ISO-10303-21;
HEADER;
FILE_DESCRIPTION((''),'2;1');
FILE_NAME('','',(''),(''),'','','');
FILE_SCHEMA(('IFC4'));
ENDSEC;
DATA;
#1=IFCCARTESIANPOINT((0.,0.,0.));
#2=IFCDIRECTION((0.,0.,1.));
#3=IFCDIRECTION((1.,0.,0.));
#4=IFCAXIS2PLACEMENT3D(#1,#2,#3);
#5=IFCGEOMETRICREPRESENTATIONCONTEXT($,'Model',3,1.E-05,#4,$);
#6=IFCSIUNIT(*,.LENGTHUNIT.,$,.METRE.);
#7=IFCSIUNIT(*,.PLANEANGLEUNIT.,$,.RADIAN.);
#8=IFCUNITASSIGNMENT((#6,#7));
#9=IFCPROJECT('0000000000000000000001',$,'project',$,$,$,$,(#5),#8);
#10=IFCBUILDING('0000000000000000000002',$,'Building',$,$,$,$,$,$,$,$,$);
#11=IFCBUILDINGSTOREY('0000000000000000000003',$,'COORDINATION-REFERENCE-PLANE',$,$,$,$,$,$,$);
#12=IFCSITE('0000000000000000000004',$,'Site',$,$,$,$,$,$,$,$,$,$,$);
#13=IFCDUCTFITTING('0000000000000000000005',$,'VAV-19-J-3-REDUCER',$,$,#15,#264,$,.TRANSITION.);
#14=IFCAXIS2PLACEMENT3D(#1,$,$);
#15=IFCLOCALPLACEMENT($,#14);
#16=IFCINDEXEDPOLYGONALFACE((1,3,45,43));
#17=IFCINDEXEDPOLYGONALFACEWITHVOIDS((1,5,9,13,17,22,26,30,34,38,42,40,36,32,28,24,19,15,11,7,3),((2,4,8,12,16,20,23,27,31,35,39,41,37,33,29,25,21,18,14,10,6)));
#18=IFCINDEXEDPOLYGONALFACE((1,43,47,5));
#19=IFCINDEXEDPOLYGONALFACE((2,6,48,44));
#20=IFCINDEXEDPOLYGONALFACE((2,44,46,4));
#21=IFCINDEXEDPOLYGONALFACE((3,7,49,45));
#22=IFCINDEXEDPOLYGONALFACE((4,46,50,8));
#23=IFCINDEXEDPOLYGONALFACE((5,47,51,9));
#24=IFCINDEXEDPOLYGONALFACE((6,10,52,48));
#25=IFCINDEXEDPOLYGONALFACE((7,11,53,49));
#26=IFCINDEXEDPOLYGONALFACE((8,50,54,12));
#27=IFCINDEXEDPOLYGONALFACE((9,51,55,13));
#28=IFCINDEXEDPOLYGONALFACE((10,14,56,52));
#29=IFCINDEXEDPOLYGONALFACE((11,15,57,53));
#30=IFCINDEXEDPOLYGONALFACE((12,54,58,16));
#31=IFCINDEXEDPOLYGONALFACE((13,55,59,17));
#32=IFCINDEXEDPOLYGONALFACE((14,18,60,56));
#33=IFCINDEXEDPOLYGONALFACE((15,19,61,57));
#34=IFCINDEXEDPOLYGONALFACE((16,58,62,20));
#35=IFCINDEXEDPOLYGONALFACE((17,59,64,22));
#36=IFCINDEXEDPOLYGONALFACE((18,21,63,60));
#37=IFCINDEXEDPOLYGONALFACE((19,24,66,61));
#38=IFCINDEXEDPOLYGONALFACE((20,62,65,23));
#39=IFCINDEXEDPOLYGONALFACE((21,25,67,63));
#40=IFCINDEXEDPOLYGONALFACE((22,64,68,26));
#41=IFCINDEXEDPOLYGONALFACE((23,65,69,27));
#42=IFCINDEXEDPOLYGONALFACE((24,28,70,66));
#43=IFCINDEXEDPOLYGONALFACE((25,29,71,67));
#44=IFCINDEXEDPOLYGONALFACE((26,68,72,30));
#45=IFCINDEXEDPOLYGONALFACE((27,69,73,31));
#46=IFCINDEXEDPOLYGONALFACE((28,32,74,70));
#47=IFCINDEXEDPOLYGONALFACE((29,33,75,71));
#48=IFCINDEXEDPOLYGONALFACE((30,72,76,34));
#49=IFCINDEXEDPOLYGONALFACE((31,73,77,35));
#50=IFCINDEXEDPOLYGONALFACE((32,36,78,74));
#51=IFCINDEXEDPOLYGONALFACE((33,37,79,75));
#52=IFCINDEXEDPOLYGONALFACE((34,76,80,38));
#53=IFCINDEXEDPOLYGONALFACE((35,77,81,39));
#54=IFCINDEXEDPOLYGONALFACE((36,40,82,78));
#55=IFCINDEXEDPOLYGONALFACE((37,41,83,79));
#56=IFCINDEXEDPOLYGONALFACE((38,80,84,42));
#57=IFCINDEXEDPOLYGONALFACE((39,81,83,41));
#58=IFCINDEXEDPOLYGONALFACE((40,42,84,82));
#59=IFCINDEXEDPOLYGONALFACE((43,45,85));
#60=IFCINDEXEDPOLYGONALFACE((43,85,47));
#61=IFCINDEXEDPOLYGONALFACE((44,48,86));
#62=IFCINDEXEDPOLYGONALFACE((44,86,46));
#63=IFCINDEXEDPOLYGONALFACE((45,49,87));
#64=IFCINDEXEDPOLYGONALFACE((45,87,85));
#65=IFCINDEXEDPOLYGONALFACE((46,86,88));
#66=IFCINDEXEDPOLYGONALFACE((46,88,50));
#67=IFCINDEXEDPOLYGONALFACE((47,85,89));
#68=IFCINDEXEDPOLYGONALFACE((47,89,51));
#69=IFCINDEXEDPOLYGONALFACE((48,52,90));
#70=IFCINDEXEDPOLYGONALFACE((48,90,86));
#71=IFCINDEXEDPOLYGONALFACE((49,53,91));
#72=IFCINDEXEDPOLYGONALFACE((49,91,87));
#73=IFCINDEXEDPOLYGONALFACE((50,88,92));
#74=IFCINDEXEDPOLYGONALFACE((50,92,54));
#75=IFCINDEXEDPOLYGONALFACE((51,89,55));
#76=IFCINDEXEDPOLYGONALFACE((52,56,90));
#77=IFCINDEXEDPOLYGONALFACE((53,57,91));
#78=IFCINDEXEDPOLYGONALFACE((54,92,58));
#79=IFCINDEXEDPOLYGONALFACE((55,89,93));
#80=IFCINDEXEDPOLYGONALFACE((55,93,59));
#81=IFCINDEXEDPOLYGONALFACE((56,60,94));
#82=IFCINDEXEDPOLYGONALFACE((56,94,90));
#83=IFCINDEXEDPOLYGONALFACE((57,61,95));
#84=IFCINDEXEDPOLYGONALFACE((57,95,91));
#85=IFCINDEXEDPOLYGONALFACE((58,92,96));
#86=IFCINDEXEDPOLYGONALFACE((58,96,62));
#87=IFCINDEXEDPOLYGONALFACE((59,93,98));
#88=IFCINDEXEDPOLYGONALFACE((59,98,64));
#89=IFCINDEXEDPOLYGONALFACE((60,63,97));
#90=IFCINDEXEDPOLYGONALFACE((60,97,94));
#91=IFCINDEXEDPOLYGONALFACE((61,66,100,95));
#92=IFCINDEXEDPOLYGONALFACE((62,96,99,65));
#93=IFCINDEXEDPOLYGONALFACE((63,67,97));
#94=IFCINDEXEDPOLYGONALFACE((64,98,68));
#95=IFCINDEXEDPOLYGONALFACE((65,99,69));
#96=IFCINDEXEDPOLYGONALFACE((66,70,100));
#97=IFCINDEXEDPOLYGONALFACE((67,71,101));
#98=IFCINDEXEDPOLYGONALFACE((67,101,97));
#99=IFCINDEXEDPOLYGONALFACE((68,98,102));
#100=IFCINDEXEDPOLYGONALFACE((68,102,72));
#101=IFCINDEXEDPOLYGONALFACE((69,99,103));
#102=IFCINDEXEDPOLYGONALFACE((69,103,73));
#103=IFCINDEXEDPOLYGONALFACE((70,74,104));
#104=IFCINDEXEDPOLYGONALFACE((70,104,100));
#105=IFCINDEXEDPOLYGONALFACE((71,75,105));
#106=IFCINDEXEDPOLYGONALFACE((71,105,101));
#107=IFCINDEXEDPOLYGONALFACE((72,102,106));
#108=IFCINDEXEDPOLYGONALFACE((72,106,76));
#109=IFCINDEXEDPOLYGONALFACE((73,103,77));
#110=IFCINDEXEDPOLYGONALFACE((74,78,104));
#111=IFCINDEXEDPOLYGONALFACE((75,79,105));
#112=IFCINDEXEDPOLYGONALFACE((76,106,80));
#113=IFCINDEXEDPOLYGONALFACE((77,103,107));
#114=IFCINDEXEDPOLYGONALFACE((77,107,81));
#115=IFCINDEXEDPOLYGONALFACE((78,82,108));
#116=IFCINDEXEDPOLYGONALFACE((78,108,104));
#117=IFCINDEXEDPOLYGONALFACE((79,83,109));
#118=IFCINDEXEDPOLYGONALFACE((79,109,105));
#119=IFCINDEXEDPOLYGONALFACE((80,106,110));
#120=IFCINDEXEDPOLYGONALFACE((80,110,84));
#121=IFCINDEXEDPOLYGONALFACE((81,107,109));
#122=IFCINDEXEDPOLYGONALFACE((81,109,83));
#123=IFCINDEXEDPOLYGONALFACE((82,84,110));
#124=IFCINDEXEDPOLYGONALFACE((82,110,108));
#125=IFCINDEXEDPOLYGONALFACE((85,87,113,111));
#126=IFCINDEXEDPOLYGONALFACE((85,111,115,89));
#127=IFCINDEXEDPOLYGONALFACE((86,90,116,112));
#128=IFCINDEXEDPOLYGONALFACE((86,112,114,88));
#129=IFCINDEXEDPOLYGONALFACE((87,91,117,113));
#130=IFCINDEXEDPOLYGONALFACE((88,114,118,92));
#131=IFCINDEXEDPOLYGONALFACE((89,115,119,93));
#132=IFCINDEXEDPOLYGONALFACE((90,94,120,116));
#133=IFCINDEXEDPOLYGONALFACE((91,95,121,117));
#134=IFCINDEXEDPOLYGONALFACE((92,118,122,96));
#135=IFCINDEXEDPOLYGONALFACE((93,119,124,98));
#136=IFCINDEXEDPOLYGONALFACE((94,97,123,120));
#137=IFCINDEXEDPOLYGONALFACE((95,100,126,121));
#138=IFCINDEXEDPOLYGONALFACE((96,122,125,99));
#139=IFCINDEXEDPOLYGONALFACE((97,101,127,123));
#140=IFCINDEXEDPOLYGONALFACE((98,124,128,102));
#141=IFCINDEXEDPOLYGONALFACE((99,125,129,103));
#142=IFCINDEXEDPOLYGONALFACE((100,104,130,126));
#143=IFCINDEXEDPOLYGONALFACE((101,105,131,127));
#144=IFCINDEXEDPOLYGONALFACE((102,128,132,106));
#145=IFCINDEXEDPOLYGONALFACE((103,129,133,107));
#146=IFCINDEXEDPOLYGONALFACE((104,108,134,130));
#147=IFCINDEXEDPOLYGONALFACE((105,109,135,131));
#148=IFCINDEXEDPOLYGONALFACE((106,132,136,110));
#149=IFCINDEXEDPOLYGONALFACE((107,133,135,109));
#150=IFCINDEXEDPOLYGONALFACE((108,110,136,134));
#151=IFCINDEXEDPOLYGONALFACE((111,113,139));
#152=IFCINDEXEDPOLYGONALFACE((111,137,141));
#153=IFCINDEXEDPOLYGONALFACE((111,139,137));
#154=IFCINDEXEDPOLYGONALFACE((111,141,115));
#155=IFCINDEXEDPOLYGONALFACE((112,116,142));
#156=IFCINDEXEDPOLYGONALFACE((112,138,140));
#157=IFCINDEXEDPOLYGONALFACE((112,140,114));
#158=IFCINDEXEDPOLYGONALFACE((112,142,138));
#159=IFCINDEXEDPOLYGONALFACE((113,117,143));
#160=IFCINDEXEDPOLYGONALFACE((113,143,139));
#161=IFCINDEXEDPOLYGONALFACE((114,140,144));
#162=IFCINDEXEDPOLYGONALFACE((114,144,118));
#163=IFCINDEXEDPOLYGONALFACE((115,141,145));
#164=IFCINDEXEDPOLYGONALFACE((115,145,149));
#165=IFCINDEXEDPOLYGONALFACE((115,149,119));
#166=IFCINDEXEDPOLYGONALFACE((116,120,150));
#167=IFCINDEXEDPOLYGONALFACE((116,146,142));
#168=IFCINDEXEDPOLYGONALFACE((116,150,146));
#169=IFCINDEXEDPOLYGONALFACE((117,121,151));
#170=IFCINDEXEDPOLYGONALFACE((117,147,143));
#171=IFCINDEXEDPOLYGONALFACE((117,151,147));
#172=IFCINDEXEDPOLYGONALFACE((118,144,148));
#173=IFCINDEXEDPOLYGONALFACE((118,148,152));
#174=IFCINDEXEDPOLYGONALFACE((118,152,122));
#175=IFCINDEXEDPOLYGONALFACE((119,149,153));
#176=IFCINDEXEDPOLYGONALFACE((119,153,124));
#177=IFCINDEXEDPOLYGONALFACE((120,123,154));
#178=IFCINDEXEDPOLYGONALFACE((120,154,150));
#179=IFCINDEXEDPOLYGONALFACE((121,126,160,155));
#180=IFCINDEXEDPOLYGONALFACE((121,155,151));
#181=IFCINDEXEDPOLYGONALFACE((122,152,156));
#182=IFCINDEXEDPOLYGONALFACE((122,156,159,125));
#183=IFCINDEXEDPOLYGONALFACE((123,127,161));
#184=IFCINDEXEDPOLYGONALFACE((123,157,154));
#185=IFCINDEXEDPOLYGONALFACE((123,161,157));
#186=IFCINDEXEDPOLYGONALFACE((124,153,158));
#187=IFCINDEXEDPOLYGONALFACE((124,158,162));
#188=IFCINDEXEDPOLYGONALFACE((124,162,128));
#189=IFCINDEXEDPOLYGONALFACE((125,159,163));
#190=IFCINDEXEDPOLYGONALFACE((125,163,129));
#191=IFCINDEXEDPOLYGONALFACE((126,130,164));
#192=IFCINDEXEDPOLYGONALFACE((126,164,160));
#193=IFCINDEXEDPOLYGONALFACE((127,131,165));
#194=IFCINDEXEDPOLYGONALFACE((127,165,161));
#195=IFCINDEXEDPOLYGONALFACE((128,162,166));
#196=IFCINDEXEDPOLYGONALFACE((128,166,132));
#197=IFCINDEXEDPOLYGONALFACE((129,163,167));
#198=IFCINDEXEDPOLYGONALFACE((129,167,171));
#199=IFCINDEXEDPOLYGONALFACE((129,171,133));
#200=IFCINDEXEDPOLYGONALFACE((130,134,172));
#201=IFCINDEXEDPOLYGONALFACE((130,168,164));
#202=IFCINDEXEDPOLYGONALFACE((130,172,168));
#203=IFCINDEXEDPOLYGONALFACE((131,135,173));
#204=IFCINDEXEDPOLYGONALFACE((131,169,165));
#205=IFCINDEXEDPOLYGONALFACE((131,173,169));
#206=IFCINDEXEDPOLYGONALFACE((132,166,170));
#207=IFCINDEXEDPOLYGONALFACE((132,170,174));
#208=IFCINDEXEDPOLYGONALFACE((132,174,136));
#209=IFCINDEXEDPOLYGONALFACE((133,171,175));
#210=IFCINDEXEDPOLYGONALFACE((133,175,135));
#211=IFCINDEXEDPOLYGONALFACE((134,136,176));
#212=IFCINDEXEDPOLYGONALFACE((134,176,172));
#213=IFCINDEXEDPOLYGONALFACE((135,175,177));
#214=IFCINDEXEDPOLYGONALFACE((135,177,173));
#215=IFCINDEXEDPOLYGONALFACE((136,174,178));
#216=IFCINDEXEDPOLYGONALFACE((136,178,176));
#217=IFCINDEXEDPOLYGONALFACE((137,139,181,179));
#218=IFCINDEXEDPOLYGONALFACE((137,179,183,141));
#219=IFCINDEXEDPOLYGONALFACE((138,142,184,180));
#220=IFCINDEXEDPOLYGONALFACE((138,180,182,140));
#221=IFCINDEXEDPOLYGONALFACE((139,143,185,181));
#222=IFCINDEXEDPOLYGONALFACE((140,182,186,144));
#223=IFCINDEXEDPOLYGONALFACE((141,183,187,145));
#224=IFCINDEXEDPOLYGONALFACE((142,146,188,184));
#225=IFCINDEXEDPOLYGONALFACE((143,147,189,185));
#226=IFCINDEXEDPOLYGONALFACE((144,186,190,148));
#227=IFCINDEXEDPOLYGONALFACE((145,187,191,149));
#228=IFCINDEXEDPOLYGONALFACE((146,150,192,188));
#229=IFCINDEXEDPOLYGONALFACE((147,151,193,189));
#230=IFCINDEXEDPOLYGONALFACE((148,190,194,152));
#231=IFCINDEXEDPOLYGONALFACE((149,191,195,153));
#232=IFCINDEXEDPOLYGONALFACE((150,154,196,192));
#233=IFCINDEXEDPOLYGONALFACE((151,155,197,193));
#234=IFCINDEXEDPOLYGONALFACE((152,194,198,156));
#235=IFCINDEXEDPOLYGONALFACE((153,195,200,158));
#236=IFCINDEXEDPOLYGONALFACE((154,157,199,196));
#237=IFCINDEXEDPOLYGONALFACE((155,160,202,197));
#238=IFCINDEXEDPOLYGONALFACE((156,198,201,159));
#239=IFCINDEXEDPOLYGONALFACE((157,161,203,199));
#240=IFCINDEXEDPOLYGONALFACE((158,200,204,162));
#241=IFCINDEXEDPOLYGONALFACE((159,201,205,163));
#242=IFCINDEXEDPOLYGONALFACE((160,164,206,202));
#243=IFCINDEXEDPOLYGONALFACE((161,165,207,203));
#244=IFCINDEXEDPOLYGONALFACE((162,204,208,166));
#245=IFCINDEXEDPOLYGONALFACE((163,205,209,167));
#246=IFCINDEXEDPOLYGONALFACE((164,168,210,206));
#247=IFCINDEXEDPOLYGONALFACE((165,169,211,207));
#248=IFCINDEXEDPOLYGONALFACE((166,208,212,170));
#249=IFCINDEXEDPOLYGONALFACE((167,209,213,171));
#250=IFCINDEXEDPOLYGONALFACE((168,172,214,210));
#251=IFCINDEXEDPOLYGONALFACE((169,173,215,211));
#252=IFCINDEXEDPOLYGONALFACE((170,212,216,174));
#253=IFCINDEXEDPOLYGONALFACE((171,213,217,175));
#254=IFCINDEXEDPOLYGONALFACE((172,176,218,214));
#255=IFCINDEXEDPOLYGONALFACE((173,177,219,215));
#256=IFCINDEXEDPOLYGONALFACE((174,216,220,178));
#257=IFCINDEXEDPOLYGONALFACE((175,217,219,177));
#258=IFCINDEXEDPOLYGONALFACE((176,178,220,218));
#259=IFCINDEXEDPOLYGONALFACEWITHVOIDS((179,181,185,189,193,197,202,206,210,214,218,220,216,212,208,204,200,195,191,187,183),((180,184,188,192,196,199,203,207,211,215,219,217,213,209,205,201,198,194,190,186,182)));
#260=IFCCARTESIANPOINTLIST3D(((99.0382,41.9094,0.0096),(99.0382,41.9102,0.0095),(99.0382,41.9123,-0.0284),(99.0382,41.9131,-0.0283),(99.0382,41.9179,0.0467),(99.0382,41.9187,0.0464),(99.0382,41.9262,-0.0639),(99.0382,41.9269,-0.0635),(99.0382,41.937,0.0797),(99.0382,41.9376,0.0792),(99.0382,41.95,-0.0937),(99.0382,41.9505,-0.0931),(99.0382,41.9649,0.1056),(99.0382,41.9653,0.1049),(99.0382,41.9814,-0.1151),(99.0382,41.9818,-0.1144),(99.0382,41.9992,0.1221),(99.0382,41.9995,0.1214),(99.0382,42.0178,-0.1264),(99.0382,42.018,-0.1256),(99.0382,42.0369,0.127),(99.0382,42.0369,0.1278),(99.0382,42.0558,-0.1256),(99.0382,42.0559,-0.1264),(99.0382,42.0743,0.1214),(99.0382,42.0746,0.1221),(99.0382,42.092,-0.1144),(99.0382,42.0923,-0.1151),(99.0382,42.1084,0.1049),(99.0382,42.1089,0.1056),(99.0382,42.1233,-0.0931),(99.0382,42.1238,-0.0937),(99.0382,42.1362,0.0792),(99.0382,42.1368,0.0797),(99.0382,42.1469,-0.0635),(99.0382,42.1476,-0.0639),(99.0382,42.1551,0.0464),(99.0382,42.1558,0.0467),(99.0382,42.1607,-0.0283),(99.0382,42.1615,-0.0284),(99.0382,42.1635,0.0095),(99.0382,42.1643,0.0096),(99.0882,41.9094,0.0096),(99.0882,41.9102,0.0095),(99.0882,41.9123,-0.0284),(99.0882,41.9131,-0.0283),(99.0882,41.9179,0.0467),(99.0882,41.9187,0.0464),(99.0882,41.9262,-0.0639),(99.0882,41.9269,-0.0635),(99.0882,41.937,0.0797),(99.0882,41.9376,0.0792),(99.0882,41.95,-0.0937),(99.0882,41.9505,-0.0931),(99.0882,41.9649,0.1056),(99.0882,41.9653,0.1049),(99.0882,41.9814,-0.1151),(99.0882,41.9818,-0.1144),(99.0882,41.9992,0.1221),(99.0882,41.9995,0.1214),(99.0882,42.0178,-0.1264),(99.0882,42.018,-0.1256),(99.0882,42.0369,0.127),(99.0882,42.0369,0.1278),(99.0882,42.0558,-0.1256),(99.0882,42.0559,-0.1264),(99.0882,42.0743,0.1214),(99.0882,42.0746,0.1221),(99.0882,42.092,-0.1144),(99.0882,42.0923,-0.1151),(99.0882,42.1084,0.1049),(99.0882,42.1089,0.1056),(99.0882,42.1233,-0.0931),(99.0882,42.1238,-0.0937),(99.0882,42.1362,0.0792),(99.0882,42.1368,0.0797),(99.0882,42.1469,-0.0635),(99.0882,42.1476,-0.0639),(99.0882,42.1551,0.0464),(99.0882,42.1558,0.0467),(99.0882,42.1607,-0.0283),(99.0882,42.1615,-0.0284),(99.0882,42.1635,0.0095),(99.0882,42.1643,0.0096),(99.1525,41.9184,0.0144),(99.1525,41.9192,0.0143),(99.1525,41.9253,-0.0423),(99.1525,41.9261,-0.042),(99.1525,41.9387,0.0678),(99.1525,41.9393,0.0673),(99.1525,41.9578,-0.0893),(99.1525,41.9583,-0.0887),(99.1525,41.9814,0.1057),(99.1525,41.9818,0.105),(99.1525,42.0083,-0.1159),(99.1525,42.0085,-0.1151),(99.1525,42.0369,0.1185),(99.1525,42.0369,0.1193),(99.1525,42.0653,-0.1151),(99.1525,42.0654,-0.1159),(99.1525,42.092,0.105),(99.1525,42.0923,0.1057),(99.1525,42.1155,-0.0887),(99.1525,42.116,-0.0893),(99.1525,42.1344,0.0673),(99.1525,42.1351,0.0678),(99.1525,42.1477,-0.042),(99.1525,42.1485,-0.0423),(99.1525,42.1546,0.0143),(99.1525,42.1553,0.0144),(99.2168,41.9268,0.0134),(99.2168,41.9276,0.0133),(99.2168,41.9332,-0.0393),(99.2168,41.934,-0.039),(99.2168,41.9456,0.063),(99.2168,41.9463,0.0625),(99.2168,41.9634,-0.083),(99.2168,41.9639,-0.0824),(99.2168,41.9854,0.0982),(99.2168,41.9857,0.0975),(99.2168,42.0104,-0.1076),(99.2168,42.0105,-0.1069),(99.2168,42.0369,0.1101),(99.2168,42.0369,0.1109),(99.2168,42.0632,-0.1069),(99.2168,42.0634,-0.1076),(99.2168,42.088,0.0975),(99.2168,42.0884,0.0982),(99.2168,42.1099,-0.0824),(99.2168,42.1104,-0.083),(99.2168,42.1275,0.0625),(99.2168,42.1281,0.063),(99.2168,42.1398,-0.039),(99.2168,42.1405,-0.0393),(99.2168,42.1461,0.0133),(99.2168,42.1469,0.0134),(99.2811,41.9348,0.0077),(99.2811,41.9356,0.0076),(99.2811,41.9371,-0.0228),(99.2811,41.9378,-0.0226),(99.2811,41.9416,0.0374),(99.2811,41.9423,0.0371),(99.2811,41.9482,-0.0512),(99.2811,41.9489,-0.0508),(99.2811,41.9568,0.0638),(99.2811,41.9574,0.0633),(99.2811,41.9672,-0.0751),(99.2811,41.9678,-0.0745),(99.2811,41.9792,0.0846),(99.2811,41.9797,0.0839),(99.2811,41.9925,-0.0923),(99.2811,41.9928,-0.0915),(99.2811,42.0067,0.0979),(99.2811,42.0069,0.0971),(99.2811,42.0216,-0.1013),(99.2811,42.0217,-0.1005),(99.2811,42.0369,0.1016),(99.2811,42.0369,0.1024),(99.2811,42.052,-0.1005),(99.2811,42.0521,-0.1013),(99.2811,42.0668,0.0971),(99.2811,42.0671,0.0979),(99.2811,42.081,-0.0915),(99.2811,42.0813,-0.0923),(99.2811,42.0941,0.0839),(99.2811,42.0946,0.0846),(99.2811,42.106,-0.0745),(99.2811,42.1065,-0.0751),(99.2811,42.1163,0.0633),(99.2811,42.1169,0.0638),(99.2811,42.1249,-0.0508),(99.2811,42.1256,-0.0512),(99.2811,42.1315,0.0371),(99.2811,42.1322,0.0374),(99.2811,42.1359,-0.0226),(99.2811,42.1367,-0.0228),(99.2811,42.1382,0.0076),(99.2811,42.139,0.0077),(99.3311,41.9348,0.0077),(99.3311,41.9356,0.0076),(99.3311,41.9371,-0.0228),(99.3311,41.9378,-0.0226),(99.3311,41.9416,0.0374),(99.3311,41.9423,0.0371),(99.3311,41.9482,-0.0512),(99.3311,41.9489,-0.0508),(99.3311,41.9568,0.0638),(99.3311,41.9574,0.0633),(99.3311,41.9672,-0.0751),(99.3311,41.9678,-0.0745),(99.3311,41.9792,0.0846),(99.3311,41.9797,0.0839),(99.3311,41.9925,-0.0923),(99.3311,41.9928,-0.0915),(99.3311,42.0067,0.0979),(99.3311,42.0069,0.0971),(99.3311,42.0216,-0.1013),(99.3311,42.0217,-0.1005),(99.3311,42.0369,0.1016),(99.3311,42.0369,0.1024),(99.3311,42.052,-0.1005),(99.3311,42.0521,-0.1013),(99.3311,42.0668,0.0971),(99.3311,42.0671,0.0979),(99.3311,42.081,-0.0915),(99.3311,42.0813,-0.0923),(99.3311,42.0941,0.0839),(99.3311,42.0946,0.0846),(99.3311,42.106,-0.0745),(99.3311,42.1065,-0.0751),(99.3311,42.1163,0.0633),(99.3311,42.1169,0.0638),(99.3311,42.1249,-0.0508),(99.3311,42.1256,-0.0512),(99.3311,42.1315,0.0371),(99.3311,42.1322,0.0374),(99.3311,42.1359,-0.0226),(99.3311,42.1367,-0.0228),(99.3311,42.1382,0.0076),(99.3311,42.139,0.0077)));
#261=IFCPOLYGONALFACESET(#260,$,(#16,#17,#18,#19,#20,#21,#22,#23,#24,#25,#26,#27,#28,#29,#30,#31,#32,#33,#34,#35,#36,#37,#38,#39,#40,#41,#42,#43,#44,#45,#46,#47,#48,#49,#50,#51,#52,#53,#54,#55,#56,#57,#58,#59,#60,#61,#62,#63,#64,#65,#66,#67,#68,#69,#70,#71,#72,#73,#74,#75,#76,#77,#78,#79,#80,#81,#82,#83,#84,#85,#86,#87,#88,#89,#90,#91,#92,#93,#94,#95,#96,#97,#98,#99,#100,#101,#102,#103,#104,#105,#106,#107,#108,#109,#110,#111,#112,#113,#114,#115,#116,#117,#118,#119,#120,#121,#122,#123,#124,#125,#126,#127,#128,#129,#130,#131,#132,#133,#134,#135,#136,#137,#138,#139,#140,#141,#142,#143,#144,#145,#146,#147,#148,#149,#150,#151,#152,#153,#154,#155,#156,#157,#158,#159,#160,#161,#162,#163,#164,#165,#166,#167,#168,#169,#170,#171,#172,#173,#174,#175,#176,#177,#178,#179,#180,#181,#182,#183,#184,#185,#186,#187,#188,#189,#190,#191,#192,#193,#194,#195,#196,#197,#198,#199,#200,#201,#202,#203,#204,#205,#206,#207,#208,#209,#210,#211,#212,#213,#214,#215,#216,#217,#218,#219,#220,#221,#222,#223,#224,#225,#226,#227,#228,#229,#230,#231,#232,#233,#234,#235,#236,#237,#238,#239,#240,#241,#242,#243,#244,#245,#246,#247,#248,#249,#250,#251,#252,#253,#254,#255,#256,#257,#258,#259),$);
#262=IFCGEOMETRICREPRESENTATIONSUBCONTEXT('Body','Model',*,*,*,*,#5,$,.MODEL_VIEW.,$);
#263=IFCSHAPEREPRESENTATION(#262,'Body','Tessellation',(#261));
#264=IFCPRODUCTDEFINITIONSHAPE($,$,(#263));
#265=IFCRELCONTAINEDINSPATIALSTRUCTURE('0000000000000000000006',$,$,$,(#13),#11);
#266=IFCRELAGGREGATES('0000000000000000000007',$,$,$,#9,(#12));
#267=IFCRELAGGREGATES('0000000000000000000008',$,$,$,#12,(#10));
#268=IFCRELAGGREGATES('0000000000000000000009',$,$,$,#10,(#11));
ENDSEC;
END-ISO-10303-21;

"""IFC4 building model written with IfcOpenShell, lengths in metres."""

from ifc_helpers import new_model, entity, si_unit, frame, origin_with_axes, place, context, subcontext, project, spatial, element, save


model = new_model("IFC4")

# Units and contexts
model_context = context("Model", 3, precision=1e-05, world=origin_with_axes())
body_context_1 = subcontext(model_context, "Body", "Model", "MODEL_VIEW")
ifc_project = project(units=[si_unit("LENGTHUNIT", "METRE"), si_unit("PLANEANGLEUNIT", "RADIAN")], contexts=[model_context])

# Site, building, storey
site = spatial("IfcSite", under=ifc_project, Name="Site")
building = spatial("IfcBuilding", under=site, Name="Building")
storey = spatial("IfcBuildingStorey", under=building, Name="COORDINATION-REFERENCE-PLANE")

# Duct fitting
for number, where, z_axis, x_axis, name in (
    (1, (99.0382, 42.0369, 0.0), (0.0, 1.0, 0.0), (0.0, 0.0, 1.0), "VAV-19-J-3-REDUCER"),
):
    element("IfcDuctFitting", number, at=place(None, frame(where, z_axis=z_axis, x_axis=x_axis)), inside=storey, Name=name, PredefinedType="TRANSITION", context=body_context_1, shape_type="SweptSolid", body=[
        entity("IfcRevolvedAreaSolid", entity("IfcArbitraryClosedProfileDef", "AREA", None, entity("IfcPolyline", [entity("IfcCartesianPoint", [0.1278, 0.0]), entity("IfcCartesianPoint", [0.1278, 0.05]), entity("IfcCartesianPoint", [0.1024, 0.2429]), entity("IfcCartesianPoint", [0.1024, 0.2929]), entity("IfcCartesianPoint", [0.1016, 0.2929]), entity("IfcCartesianPoint", [0.1016, 0.2429]), entity("IfcCartesianPoint", [0.127, 0.05]), entity("IfcCartesianPoint", [0.127, 0.0]), entity("IfcCartesianPoint", [0.1278, 0.0])])), entity("IfcAxis2Placement3D", entity("IfcCartesianPoint", [0.0, 0.0, 0.0])), entity("IfcAxis1Placement", entity("IfcCartesianPoint", [0.0, 0.0, 0.0]), entity("IfcDirection", [0.0, 1.0, 0.0])), 6.283185),
    ])

save(model, "model.ifc")
